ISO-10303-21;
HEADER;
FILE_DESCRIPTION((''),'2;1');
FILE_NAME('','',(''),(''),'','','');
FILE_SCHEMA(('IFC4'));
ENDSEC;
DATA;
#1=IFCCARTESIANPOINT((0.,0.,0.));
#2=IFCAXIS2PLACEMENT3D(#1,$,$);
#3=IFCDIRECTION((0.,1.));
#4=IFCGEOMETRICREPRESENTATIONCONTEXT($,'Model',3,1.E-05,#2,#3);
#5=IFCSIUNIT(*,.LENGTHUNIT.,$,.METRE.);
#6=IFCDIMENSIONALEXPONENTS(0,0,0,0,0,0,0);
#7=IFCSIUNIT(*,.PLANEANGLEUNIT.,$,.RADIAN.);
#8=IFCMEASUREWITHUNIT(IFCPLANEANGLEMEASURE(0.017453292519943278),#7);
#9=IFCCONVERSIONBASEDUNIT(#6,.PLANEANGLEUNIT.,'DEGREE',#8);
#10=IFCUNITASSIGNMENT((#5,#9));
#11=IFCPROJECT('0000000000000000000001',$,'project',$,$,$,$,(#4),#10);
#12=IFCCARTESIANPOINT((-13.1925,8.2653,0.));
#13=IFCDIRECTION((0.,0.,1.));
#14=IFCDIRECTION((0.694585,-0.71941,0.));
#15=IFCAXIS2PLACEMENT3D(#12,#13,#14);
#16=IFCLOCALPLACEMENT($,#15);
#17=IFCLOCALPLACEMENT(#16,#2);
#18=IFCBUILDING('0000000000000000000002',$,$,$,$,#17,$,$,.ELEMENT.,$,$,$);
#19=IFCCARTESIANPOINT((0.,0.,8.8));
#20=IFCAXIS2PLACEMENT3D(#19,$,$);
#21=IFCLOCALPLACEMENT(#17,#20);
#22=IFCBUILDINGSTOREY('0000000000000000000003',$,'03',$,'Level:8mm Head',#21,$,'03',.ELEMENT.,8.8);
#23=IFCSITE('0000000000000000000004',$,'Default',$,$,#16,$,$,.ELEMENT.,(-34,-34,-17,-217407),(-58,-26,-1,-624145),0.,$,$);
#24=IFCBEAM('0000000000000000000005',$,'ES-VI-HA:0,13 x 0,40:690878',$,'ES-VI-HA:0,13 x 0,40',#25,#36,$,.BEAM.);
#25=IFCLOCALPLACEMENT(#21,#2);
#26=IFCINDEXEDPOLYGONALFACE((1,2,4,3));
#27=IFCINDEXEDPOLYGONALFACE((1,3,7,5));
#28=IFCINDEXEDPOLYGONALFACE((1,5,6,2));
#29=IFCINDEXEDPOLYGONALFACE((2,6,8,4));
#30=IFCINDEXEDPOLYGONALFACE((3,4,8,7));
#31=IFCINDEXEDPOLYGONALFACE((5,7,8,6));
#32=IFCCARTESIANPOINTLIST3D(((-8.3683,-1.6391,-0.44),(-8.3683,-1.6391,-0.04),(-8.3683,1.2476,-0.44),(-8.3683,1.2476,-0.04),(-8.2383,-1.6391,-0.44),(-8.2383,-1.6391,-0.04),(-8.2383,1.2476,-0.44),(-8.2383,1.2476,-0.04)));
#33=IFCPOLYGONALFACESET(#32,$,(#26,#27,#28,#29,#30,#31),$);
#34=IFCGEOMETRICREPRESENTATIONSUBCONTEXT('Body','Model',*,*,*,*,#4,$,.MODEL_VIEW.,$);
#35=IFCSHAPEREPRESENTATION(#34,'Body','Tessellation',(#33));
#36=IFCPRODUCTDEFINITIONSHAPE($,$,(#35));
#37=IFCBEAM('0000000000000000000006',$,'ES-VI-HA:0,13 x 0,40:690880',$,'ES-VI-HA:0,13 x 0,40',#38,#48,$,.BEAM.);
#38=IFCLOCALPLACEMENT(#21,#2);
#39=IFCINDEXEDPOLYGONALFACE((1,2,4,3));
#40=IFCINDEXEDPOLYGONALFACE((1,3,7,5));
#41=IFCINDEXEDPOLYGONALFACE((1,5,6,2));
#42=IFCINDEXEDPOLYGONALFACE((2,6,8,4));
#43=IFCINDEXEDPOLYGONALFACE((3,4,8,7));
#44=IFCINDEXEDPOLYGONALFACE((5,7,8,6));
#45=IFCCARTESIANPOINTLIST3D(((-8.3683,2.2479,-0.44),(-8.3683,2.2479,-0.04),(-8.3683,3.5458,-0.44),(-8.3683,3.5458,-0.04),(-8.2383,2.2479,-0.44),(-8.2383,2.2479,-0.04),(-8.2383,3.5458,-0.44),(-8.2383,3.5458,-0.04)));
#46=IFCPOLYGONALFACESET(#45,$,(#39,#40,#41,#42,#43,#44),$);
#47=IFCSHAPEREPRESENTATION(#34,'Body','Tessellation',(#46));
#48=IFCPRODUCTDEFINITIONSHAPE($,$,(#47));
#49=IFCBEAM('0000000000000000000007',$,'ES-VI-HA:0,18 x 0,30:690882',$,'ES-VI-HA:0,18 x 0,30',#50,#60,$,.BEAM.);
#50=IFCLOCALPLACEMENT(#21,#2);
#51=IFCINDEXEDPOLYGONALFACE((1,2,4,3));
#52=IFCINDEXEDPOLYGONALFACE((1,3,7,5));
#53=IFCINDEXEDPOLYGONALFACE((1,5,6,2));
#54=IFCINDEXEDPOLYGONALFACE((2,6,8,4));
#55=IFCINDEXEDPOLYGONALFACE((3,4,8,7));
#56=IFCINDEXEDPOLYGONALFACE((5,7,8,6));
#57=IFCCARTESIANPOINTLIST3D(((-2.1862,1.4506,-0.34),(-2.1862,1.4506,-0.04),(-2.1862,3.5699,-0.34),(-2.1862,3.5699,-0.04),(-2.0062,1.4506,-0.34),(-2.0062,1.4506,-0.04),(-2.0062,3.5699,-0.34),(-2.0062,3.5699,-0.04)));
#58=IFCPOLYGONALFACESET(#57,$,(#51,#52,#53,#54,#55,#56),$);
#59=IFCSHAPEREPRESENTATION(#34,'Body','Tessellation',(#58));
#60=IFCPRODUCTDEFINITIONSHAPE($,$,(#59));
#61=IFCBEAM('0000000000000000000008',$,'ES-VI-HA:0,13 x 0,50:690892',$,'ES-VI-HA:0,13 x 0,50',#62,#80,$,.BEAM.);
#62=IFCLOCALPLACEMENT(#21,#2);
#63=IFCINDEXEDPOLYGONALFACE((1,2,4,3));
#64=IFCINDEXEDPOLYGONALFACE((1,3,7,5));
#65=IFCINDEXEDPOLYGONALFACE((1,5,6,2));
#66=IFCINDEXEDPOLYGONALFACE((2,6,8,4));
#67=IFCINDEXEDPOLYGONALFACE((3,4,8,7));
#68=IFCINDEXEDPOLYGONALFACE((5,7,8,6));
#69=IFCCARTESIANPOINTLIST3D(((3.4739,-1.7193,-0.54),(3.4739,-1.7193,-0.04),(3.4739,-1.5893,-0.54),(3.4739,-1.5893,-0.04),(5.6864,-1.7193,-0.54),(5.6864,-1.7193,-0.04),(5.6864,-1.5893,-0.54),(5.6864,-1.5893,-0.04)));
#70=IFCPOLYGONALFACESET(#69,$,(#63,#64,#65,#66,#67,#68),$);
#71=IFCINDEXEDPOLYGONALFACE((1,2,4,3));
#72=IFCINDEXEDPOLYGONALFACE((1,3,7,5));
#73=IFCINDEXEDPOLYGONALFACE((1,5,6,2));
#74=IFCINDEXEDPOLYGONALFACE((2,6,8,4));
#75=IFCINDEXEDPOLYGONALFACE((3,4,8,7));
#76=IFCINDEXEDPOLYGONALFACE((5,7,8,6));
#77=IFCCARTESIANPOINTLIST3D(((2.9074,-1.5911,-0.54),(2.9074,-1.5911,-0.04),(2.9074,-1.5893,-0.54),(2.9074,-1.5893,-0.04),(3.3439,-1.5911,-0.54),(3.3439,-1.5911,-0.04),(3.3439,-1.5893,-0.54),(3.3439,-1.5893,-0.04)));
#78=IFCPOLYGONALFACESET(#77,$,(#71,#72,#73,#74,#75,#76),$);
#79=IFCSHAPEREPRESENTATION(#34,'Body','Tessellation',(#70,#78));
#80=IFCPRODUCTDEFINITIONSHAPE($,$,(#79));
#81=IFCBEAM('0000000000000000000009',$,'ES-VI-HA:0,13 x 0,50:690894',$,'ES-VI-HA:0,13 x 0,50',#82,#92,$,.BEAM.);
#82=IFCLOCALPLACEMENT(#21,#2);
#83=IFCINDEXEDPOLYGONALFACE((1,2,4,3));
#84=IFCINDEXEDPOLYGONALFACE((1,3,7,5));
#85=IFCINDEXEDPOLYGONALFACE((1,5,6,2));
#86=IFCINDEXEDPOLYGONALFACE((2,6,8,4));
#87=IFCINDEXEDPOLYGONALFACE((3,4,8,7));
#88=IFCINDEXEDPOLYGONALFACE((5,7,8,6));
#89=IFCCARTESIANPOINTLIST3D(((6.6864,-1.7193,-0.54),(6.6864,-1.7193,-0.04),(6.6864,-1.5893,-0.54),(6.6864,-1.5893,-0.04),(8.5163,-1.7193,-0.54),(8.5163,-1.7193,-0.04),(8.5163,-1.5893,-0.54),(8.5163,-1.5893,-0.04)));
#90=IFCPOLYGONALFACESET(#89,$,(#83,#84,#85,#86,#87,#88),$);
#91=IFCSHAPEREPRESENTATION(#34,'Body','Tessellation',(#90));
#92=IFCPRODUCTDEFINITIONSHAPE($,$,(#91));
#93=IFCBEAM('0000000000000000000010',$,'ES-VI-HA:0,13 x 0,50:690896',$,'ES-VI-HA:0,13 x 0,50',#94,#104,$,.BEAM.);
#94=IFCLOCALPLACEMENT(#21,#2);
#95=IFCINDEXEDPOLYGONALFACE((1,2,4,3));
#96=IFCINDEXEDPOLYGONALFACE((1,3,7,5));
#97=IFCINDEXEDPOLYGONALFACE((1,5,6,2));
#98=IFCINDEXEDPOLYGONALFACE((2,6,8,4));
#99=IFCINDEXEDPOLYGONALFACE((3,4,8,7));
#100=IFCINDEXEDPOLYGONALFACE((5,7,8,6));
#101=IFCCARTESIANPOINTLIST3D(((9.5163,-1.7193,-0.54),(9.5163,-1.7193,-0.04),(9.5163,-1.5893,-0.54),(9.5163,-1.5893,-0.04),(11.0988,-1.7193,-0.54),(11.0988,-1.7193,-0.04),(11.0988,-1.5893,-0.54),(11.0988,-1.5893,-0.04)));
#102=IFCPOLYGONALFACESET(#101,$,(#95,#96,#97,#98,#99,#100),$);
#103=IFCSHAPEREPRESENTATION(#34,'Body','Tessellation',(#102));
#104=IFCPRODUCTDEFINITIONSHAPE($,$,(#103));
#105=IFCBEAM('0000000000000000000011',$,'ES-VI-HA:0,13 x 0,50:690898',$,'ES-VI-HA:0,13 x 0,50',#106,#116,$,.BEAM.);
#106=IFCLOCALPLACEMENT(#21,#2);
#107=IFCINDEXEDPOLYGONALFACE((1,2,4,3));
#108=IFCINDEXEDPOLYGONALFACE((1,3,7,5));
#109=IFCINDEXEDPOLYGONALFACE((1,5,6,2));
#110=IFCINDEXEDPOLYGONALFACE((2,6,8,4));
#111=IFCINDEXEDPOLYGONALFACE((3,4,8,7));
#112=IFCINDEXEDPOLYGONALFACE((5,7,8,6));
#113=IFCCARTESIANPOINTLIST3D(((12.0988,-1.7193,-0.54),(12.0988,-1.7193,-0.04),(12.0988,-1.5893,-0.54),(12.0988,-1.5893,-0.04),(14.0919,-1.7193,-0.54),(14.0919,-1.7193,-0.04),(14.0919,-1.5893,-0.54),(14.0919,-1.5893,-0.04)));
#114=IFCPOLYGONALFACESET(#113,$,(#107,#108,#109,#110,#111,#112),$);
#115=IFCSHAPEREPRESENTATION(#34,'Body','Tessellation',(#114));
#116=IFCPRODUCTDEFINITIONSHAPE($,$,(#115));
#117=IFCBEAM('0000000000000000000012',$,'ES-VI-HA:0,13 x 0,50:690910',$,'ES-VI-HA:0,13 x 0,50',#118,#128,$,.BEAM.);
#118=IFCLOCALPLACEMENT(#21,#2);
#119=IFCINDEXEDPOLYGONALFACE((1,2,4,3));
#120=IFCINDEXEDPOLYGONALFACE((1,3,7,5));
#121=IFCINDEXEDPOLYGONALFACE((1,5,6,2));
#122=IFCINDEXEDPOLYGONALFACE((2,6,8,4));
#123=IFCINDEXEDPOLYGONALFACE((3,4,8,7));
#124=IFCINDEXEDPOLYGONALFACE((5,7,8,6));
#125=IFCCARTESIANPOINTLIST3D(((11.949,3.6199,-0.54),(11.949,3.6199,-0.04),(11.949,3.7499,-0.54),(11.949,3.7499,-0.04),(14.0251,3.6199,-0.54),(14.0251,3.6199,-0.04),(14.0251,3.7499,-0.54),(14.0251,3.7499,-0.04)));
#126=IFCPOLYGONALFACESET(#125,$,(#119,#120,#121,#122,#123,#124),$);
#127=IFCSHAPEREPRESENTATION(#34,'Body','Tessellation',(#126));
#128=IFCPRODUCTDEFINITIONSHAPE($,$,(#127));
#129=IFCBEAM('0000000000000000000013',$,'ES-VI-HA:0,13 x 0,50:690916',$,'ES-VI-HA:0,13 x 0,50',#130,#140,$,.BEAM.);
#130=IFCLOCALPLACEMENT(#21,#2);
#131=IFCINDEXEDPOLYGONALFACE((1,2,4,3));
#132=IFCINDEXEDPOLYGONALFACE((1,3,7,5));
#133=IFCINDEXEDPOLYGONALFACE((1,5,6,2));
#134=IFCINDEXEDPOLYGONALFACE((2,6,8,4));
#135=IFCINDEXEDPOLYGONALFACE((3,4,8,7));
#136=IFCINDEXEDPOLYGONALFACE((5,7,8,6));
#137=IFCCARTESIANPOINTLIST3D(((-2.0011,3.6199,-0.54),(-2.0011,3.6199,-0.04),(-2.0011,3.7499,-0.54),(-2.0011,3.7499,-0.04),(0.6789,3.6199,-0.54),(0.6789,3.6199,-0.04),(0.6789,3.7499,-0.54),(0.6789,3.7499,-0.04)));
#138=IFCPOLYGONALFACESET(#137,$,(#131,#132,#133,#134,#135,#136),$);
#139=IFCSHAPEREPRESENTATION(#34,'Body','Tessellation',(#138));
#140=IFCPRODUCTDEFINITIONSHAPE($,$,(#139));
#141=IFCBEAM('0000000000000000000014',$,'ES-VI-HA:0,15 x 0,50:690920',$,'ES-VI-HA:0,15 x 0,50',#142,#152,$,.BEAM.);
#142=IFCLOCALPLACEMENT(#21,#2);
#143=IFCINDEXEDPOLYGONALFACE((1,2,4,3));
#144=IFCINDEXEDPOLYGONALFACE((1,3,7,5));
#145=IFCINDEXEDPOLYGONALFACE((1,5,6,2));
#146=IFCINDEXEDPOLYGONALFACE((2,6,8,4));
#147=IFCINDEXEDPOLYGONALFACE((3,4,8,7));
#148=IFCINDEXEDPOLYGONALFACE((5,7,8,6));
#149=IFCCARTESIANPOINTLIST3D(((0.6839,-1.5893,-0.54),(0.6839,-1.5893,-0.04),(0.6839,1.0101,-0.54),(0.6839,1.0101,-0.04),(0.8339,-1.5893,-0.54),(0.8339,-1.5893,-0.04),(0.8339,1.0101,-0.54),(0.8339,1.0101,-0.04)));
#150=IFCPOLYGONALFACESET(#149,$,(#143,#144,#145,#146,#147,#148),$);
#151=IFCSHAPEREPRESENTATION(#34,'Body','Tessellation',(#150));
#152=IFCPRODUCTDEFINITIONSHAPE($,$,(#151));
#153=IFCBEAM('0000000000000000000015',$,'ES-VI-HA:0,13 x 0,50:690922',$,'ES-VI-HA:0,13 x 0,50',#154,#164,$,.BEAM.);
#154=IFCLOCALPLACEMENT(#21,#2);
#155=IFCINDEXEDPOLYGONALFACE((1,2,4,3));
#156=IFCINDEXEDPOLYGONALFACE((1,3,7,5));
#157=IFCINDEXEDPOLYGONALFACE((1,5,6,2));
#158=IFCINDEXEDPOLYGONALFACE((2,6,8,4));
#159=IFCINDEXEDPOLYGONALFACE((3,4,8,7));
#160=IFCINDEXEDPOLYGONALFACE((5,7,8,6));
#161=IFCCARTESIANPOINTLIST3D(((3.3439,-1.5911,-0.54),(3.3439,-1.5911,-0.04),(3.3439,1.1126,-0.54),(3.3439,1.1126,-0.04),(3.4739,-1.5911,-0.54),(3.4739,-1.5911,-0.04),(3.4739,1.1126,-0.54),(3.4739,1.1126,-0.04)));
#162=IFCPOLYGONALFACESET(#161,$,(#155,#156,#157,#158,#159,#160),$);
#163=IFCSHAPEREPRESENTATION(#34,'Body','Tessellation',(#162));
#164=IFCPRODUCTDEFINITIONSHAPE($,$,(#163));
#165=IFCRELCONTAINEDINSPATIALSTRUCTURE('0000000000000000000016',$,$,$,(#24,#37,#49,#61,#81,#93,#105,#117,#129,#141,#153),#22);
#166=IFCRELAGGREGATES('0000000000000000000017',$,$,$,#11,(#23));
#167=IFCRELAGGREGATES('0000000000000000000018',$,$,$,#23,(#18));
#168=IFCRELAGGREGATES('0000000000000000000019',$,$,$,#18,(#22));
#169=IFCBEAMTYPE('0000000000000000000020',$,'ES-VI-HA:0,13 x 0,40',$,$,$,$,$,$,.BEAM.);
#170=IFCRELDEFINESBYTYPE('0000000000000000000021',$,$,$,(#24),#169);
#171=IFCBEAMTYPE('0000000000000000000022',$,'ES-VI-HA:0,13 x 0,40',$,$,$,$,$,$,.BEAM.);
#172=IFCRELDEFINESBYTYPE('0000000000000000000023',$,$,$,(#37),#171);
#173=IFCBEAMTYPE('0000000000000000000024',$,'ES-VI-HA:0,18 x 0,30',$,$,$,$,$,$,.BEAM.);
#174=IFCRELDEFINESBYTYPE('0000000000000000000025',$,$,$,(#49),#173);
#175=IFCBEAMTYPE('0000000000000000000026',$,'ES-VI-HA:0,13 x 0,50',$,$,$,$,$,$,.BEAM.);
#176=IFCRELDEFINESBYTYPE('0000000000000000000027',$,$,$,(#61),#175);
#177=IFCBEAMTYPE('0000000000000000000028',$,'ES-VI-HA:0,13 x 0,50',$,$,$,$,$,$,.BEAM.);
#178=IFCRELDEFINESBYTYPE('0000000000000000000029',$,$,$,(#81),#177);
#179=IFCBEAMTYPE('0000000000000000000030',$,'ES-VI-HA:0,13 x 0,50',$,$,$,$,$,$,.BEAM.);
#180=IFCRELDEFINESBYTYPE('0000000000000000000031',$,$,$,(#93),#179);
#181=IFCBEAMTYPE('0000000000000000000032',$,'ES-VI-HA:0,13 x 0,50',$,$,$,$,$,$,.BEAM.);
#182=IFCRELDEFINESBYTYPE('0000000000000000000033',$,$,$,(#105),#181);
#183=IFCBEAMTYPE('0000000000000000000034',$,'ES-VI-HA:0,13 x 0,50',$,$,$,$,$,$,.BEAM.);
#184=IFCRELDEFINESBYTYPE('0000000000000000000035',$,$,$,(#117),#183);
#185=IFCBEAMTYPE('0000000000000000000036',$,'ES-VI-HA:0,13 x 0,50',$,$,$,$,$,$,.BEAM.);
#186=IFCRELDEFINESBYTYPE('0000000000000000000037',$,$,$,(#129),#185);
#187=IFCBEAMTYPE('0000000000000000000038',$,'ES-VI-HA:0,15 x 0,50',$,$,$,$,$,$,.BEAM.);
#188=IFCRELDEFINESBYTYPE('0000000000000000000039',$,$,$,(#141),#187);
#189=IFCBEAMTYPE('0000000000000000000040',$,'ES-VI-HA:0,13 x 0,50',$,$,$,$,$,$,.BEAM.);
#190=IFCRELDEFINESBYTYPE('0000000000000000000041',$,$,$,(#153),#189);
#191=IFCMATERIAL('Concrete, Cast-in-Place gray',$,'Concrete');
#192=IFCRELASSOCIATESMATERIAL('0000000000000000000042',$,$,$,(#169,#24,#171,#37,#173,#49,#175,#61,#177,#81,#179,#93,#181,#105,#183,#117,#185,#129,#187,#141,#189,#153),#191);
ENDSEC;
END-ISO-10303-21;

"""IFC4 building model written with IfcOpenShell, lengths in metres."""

from ifc_helpers import new_model, entity, si_unit, converted_unit, direction, frame, origin, place, context, subcontext, project, spatial, indexed_curve, outline, extrude, source, transform, mapped, material, type_object, type_shapes, element, save


model = new_model("IFC4")

# Units and contexts
model_context = context("Model", 3, precision=1e-05, world=origin(), true_north=direction((0.0, 1.0)))
body_context = subcontext(model_context, "Body", "Model", "MODEL_VIEW")
ifc_project = project(units=[si_unit("LENGTHUNIT", "METRE"), converted_unit("PLANEANGLEUNIT", "DEGREE", entity("IfcPlaneAngleMeasure", 0.017453292519943278), si_unit("PLANEANGLEUNIT", "RADIAN"), dimensions=[0, 0, 0, 0, 0, 0, 0])], contexts=[model_context])

# Site, building, storey
site_placement = place(None, frame((-13.1925, 8.2653, 0.0), z_axis=(0.0, 0.0, 1.0), x_axis=(0.694585, -0.71941, 0.0)))
site = spatial("IfcSite", under=ifc_project, at=site_placement, Name="Default", CompositionType="ELEMENT", RefLatitude=(-34, -34, -17, -217407), RefLongitude=(-58, -26, -1, -624145), RefElevation=0.0)
building_placement = place(site_placement, origin())
building = spatial("IfcBuilding", under=site, at=building_placement, CompositionType="ELEMENT")
storey_placement = place(building_placement, frame((0.0, 0.0, 8.8)))
storey = spatial("IfcBuildingStorey", under=building, at=storey_placement, Name="03", ObjectType="Level:8mm Head", LongName="03", CompositionType="ELEMENT", Elevation=8.8)

# Beams
ifc_material = material(Name="Concrete, Cast-in-Place gray", Category="Concrete")
beam_type_1 = type_object("IfcBeamType", Name="ES-VI-HA:0,13 x 0,40", PredefinedType="BEAM", material=ifc_material)
shared_shape_1 = source(origin(), body_context, "Body", "SweptSolid", [
    extrude(outline(indexed_curve([(-0.065, -0.2), (0.065, -0.2), (0.065, 0.2), (-0.065, 0.2), (-0.065, -0.2)], self_intersect=False)), frame((-8.3033, -1.6391, 8.56), z_axis=(0.0, 1.0, 0.0), x_axis=(-1.0, 0.0, 0.0)), (0.0, 0.0, 1.0), 2.8867),
])
type_shapes(beam_type_1, [shared_shape_1])
beam_1_placement = place(storey_placement, frame((0.0, 0.0, -8.8)))
element("IfcBeam", 1, at=beam_1_placement, inside=storey, type_object=beam_type_1, material=ifc_material, Name="ES-VI-HA:0,13 x 0,40:690878", ObjectType="ES-VI-HA:0,13 x 0,40", PredefinedType="BEAM", context=body_context, shape_type="MappedRepresentation", body=[
    mapped(shared_shape_1, transform((0.0, 0.0, 0.0), scale=1.0)),
])
beam_type_2 = type_object("IfcBeamType", Name="ES-VI-HA:0,13 x 0,40", PredefinedType="BEAM", material=ifc_material)
shared_shape_2 = source(origin(), body_context, "Body", "SweptSolid", [
    extrude(outline(indexed_curve([(-0.065, -0.2), (0.065, -0.2), (0.065, 0.2), (-0.065, 0.2), (-0.065, -0.2)], self_intersect=False)), frame((-8.3033, 2.2479, 8.56), z_axis=(0.0, 1.0, 0.0), x_axis=(-1.0, 0.0, 0.0)), (0.0, 0.0, 1.0), 1.298),
])
type_shapes(beam_type_2, [shared_shape_2])
beam_2_placement = place(storey_placement, frame((0.0, 0.0, -8.8)))
element("IfcBeam", 2, at=beam_2_placement, inside=storey, type_object=beam_type_2, material=ifc_material, Name="ES-VI-HA:0,13 x 0,40:690880", ObjectType="ES-VI-HA:0,13 x 0,40", PredefinedType="BEAM", context=body_context, shape_type="MappedRepresentation", body=[
    mapped(shared_shape_2, transform((0.0, 0.0, 0.0), scale=1.0)),
])
beam_type_3 = type_object("IfcBeamType", Name="ES-VI-HA:0,18 x 0,30", PredefinedType="BEAM", material=ifc_material)
shared_shape_3 = source(origin(), body_context, "Body", "SweptSolid", [
    extrude(outline(indexed_curve([(-0.09, -0.15), (0.09, -0.15), (0.09, 0.15), (-0.09, 0.15), (-0.09, -0.15)], self_intersect=False)), frame((-2.0962, 3.5699, 8.61), z_axis=(0.0, -1.0, 0.0), x_axis=(-1.0, 0.0, 0.0)), (0.0, 0.0, 1.0), 2.1193),
])
type_shapes(beam_type_3, [shared_shape_3])
beam_3_placement = place(storey_placement, frame((0.0, 0.0, -8.8)))
element("IfcBeam", 3, at=beam_3_placement, inside=storey, type_object=beam_type_3, material=ifc_material, Name="ES-VI-HA:0,18 x 0,30:690882", ObjectType="ES-VI-HA:0,18 x 0,30", PredefinedType="BEAM", context=body_context, shape_type="MappedRepresentation", body=[
    mapped(shared_shape_3, transform((0.0, 0.0, 0.0), scale=1.0)),
])
beam_type_4 = type_object("IfcBeamType", Name="ES-VI-HA:0,13 x 0,50", PredefinedType="BEAM", material=ifc_material)
shared_shape_4 = source(origin(), body_context, "Body", "SweptSolid", [
    extrude(outline(indexed_curve([(-0.25, -0.065), (0.25, -0.065), (0.25, 0.065), (-0.25, 0.065), (-0.25, -0.065)], self_intersect=False)), frame((3.4739, -1.6543, 8.51), z_axis=(1.0, 0.0, 0.0), x_axis=(0.0, 0.0, -1.0)), (0.0, 0.0, 1.0), 2.2125),
    extrude(outline(indexed_curve([(-0.25, -0.0009), (0.25, -0.0009), (0.25, 0.0009), (-0.25, 0.0009), (-0.25, -0.0009)], self_intersect=False)), frame((2.9074, -1.5902, 8.51), z_axis=(1.0, 0.0, 0.0), x_axis=(0.0, 0.0, -1.0)), (0.0, 0.0, 1.0), 0.4365),
])
type_shapes(beam_type_4, [shared_shape_4])
beam_4_placement = place(storey_placement, frame((0.0, 0.0, -8.8)))
element("IfcBeam", 4, at=beam_4_placement, inside=storey, type_object=beam_type_4, material=ifc_material, Name="ES-VI-HA:0,13 x 0,50:690892", ObjectType="ES-VI-HA:0,13 x 0,50", PredefinedType="BEAM", context=body_context, shape_type="MappedRepresentation", body=[
    mapped(shared_shape_4, transform((0.0, 0.0, 0.0), scale=1.0)),
])
beam_type_5 = type_object("IfcBeamType", Name="ES-VI-HA:0,13 x 0,50", PredefinedType="BEAM", material=ifc_material)
shared_shape_5 = source(origin(), body_context, "Body", "SweptSolid", [
    extrude(outline(indexed_curve([(-0.25, -0.065), (0.25, -0.065), (0.25, 0.065), (-0.25, 0.065), (-0.25, -0.065)], self_intersect=False)), frame((6.6864, -1.6543, 8.51), z_axis=(1.0, 0.0, 0.0), x_axis=(0.0, 0.0, -1.0)), (0.0, 0.0, 1.0), 1.8299),
])
type_shapes(beam_type_5, [shared_shape_5])
beam_5_placement = place(storey_placement, frame((0.0, 0.0, -8.8)))
element("IfcBeam", 5, at=beam_5_placement, inside=storey, type_object=beam_type_5, material=ifc_material, Name="ES-VI-HA:0,13 x 0,50:690894", ObjectType="ES-VI-HA:0,13 x 0,50", PredefinedType="BEAM", context=body_context, shape_type="MappedRepresentation", body=[
    mapped(shared_shape_5, transform((0.0, 0.0, 0.0), scale=1.0)),
])
beam_type_6 = type_object("IfcBeamType", Name="ES-VI-HA:0,13 x 0,50", PredefinedType="BEAM", material=ifc_material)
shared_shape_6 = source(origin(), body_context, "Body", "SweptSolid", [
    extrude(outline(indexed_curve([(-0.25, -0.065), (0.25, -0.065), (0.25, 0.065), (-0.25, 0.065), (-0.25, -0.065)], self_intersect=False)), frame((9.5163, -1.6543, 8.51), z_axis=(1.0, 0.0, 0.0), x_axis=(0.0, 0.0, -1.0)), (0.0, 0.0, 1.0), 1.5825),
])
type_shapes(beam_type_6, [shared_shape_6])
beam_6_placement = place(storey_placement, frame((0.0, 0.0, -8.8)))
element("IfcBeam", 6, at=beam_6_placement, inside=storey, type_object=beam_type_6, material=ifc_material, Name="ES-VI-HA:0,13 x 0,50:690896", ObjectType="ES-VI-HA:0,13 x 0,50", PredefinedType="BEAM", context=body_context, shape_type="MappedRepresentation", body=[
    mapped(shared_shape_6, transform((0.0, 0.0, 0.0), scale=1.0)),
])
beam_type_7 = type_object("IfcBeamType", Name="ES-VI-HA:0,13 x 0,50", PredefinedType="BEAM", material=ifc_material)
shared_shape_7 = source(origin(), body_context, "Body", "SweptSolid", [
    extrude(outline(indexed_curve([(-0.25, -0.065), (0.25, -0.065), (0.25, 0.065), (-0.25, 0.065), (-0.25, -0.065)], self_intersect=False)), frame((12.0988, -1.6543, 8.51), z_axis=(1.0, 0.0, 0.0), x_axis=(0.0, 0.0, -1.0)), (0.0, 0.0, 1.0), 1.9932),
])
type_shapes(beam_type_7, [shared_shape_7])
beam_7_placement = place(storey_placement, frame((0.0, 0.0, -8.8)))
element("IfcBeam", 7, at=beam_7_placement, inside=storey, type_object=beam_type_7, material=ifc_material, Name="ES-VI-HA:0,13 x 0,50:690898", ObjectType="ES-VI-HA:0,13 x 0,50", PredefinedType="BEAM", context=body_context, shape_type="MappedRepresentation", body=[
    mapped(shared_shape_7, transform((0.0, 0.0, 0.0), scale=1.0)),
])
beam_type_8 = type_object("IfcBeamType", Name="ES-VI-HA:0,13 x 0,50", PredefinedType="BEAM", material=ifc_material)
shared_shape_8 = source(origin(), body_context, "Body", "SweptSolid", [
    extrude(outline(indexed_curve([(-0.25, -0.065), (0.25, -0.065), (0.25, 0.065), (-0.25, 0.065), (-0.25, -0.065)], self_intersect=False)), frame((11.949, 3.6849, 8.51), z_axis=(1.0, 0.0, 0.0), x_axis=(0.0, 0.0, -1.0)), (0.0, 0.0, 1.0), 2.0761),
])
type_shapes(beam_type_8, [shared_shape_8])
beam_8_placement = place(storey_placement, frame((0.0, 0.0, -8.8)))
element("IfcBeam", 8, at=beam_8_placement, inside=storey, type_object=beam_type_8, material=ifc_material, Name="ES-VI-HA:0,13 x 0,50:690910", ObjectType="ES-VI-HA:0,13 x 0,50", PredefinedType="BEAM", context=body_context, shape_type="MappedRepresentation", body=[
    mapped(shared_shape_8, transform((0.0, 0.0, 0.0), scale=1.0)),
])
beam_type_9 = type_object("IfcBeamType", Name="ES-VI-HA:0,13 x 0,50", PredefinedType="BEAM", material=ifc_material)
shared_shape_9 = source(origin(), body_context, "Body", "SweptSolid", [
    extrude(outline(indexed_curve([(-0.25, -0.065), (0.25, -0.065), (0.25, 0.065), (-0.25, 0.065), (-0.25, -0.065)], self_intersect=False)), frame((-2.0011, 3.6849, 8.51), z_axis=(1.0, 0.0, 0.0), x_axis=(0.0, 0.0, -1.0)), (0.0, 0.0, 1.0), 2.68),
])
type_shapes(beam_type_9, [shared_shape_9])
beam_9_placement = place(storey_placement, frame((0.0, 0.0, -8.8)))
element("IfcBeam", 9, at=beam_9_placement, inside=storey, type_object=beam_type_9, material=ifc_material, Name="ES-VI-HA:0,13 x 0,50:690916", ObjectType="ES-VI-HA:0,13 x 0,50", PredefinedType="BEAM", context=body_context, shape_type="MappedRepresentation", body=[
    mapped(shared_shape_9, transform((0.0, 0.0, 0.0), scale=1.0)),
])
beam_type_10 = type_object("IfcBeamType", Name="ES-VI-HA:0,15 x 0,50", PredefinedType="BEAM", material=ifc_material)
shared_shape_10 = source(origin(), body_context, "Body", "SweptSolid", [
    extrude(outline(indexed_curve([(-0.075, -0.25), (0.075, -0.25), (0.075, 0.25), (-0.075, 0.25), (-0.075, -0.25)], self_intersect=False)), frame((0.7589, -1.5893, 8.51), z_axis=(0.0, 1.0, 0.0), x_axis=(-1.0, 0.0, 0.0)), (0.0, 0.0, 1.0), 2.5994),
])
type_shapes(beam_type_10, [shared_shape_10])
beam_10_placement = place(storey_placement, frame((0.0, 0.0, -8.8)))
element("IfcBeam", 10, at=beam_10_placement, inside=storey, type_object=beam_type_10, material=ifc_material, Name="ES-VI-HA:0,15 x 0,50:690920", ObjectType="ES-VI-HA:0,15 x 0,50", PredefinedType="BEAM", context=body_context, shape_type="MappedRepresentation", body=[
    mapped(shared_shape_10, transform((0.0, 0.0, 0.0), scale=1.0)),
])
beam_type_11 = type_object("IfcBeamType", Name="ES-VI-HA:0,13 x 0,50", PredefinedType="BEAM", material=ifc_material)
shared_shape_11 = source(origin(), body_context, "Body", "SweptSolid", [
    extrude(outline(indexed_curve([(-0.065, -0.25), (0.065, -0.25), (0.065, 0.25), (-0.065, 0.25), (-0.065, -0.25)], self_intersect=False)), frame((3.4089, -1.5911, 8.51), z_axis=(0.0, 1.0, 0.0), x_axis=(-1.0, 0.0, 0.0)), (0.0, 0.0, 1.0), 2.7037),
])
type_shapes(beam_type_11, [shared_shape_11])
beam_11_placement = place(storey_placement, frame((0.0, 0.0, -8.8)))
element("IfcBeam", 11, at=beam_11_placement, inside=storey, type_object=beam_type_11, material=ifc_material, Name="ES-VI-HA:0,13 x 0,50:690922", ObjectType="ES-VI-HA:0,13 x 0,50", PredefinedType="BEAM", context=body_context, shape_type="MappedRepresentation", body=[
    mapped(shared_shape_11, transform((0.0, 0.0, 0.0), scale=1.0)),
])

save(model, "model.ifc")
